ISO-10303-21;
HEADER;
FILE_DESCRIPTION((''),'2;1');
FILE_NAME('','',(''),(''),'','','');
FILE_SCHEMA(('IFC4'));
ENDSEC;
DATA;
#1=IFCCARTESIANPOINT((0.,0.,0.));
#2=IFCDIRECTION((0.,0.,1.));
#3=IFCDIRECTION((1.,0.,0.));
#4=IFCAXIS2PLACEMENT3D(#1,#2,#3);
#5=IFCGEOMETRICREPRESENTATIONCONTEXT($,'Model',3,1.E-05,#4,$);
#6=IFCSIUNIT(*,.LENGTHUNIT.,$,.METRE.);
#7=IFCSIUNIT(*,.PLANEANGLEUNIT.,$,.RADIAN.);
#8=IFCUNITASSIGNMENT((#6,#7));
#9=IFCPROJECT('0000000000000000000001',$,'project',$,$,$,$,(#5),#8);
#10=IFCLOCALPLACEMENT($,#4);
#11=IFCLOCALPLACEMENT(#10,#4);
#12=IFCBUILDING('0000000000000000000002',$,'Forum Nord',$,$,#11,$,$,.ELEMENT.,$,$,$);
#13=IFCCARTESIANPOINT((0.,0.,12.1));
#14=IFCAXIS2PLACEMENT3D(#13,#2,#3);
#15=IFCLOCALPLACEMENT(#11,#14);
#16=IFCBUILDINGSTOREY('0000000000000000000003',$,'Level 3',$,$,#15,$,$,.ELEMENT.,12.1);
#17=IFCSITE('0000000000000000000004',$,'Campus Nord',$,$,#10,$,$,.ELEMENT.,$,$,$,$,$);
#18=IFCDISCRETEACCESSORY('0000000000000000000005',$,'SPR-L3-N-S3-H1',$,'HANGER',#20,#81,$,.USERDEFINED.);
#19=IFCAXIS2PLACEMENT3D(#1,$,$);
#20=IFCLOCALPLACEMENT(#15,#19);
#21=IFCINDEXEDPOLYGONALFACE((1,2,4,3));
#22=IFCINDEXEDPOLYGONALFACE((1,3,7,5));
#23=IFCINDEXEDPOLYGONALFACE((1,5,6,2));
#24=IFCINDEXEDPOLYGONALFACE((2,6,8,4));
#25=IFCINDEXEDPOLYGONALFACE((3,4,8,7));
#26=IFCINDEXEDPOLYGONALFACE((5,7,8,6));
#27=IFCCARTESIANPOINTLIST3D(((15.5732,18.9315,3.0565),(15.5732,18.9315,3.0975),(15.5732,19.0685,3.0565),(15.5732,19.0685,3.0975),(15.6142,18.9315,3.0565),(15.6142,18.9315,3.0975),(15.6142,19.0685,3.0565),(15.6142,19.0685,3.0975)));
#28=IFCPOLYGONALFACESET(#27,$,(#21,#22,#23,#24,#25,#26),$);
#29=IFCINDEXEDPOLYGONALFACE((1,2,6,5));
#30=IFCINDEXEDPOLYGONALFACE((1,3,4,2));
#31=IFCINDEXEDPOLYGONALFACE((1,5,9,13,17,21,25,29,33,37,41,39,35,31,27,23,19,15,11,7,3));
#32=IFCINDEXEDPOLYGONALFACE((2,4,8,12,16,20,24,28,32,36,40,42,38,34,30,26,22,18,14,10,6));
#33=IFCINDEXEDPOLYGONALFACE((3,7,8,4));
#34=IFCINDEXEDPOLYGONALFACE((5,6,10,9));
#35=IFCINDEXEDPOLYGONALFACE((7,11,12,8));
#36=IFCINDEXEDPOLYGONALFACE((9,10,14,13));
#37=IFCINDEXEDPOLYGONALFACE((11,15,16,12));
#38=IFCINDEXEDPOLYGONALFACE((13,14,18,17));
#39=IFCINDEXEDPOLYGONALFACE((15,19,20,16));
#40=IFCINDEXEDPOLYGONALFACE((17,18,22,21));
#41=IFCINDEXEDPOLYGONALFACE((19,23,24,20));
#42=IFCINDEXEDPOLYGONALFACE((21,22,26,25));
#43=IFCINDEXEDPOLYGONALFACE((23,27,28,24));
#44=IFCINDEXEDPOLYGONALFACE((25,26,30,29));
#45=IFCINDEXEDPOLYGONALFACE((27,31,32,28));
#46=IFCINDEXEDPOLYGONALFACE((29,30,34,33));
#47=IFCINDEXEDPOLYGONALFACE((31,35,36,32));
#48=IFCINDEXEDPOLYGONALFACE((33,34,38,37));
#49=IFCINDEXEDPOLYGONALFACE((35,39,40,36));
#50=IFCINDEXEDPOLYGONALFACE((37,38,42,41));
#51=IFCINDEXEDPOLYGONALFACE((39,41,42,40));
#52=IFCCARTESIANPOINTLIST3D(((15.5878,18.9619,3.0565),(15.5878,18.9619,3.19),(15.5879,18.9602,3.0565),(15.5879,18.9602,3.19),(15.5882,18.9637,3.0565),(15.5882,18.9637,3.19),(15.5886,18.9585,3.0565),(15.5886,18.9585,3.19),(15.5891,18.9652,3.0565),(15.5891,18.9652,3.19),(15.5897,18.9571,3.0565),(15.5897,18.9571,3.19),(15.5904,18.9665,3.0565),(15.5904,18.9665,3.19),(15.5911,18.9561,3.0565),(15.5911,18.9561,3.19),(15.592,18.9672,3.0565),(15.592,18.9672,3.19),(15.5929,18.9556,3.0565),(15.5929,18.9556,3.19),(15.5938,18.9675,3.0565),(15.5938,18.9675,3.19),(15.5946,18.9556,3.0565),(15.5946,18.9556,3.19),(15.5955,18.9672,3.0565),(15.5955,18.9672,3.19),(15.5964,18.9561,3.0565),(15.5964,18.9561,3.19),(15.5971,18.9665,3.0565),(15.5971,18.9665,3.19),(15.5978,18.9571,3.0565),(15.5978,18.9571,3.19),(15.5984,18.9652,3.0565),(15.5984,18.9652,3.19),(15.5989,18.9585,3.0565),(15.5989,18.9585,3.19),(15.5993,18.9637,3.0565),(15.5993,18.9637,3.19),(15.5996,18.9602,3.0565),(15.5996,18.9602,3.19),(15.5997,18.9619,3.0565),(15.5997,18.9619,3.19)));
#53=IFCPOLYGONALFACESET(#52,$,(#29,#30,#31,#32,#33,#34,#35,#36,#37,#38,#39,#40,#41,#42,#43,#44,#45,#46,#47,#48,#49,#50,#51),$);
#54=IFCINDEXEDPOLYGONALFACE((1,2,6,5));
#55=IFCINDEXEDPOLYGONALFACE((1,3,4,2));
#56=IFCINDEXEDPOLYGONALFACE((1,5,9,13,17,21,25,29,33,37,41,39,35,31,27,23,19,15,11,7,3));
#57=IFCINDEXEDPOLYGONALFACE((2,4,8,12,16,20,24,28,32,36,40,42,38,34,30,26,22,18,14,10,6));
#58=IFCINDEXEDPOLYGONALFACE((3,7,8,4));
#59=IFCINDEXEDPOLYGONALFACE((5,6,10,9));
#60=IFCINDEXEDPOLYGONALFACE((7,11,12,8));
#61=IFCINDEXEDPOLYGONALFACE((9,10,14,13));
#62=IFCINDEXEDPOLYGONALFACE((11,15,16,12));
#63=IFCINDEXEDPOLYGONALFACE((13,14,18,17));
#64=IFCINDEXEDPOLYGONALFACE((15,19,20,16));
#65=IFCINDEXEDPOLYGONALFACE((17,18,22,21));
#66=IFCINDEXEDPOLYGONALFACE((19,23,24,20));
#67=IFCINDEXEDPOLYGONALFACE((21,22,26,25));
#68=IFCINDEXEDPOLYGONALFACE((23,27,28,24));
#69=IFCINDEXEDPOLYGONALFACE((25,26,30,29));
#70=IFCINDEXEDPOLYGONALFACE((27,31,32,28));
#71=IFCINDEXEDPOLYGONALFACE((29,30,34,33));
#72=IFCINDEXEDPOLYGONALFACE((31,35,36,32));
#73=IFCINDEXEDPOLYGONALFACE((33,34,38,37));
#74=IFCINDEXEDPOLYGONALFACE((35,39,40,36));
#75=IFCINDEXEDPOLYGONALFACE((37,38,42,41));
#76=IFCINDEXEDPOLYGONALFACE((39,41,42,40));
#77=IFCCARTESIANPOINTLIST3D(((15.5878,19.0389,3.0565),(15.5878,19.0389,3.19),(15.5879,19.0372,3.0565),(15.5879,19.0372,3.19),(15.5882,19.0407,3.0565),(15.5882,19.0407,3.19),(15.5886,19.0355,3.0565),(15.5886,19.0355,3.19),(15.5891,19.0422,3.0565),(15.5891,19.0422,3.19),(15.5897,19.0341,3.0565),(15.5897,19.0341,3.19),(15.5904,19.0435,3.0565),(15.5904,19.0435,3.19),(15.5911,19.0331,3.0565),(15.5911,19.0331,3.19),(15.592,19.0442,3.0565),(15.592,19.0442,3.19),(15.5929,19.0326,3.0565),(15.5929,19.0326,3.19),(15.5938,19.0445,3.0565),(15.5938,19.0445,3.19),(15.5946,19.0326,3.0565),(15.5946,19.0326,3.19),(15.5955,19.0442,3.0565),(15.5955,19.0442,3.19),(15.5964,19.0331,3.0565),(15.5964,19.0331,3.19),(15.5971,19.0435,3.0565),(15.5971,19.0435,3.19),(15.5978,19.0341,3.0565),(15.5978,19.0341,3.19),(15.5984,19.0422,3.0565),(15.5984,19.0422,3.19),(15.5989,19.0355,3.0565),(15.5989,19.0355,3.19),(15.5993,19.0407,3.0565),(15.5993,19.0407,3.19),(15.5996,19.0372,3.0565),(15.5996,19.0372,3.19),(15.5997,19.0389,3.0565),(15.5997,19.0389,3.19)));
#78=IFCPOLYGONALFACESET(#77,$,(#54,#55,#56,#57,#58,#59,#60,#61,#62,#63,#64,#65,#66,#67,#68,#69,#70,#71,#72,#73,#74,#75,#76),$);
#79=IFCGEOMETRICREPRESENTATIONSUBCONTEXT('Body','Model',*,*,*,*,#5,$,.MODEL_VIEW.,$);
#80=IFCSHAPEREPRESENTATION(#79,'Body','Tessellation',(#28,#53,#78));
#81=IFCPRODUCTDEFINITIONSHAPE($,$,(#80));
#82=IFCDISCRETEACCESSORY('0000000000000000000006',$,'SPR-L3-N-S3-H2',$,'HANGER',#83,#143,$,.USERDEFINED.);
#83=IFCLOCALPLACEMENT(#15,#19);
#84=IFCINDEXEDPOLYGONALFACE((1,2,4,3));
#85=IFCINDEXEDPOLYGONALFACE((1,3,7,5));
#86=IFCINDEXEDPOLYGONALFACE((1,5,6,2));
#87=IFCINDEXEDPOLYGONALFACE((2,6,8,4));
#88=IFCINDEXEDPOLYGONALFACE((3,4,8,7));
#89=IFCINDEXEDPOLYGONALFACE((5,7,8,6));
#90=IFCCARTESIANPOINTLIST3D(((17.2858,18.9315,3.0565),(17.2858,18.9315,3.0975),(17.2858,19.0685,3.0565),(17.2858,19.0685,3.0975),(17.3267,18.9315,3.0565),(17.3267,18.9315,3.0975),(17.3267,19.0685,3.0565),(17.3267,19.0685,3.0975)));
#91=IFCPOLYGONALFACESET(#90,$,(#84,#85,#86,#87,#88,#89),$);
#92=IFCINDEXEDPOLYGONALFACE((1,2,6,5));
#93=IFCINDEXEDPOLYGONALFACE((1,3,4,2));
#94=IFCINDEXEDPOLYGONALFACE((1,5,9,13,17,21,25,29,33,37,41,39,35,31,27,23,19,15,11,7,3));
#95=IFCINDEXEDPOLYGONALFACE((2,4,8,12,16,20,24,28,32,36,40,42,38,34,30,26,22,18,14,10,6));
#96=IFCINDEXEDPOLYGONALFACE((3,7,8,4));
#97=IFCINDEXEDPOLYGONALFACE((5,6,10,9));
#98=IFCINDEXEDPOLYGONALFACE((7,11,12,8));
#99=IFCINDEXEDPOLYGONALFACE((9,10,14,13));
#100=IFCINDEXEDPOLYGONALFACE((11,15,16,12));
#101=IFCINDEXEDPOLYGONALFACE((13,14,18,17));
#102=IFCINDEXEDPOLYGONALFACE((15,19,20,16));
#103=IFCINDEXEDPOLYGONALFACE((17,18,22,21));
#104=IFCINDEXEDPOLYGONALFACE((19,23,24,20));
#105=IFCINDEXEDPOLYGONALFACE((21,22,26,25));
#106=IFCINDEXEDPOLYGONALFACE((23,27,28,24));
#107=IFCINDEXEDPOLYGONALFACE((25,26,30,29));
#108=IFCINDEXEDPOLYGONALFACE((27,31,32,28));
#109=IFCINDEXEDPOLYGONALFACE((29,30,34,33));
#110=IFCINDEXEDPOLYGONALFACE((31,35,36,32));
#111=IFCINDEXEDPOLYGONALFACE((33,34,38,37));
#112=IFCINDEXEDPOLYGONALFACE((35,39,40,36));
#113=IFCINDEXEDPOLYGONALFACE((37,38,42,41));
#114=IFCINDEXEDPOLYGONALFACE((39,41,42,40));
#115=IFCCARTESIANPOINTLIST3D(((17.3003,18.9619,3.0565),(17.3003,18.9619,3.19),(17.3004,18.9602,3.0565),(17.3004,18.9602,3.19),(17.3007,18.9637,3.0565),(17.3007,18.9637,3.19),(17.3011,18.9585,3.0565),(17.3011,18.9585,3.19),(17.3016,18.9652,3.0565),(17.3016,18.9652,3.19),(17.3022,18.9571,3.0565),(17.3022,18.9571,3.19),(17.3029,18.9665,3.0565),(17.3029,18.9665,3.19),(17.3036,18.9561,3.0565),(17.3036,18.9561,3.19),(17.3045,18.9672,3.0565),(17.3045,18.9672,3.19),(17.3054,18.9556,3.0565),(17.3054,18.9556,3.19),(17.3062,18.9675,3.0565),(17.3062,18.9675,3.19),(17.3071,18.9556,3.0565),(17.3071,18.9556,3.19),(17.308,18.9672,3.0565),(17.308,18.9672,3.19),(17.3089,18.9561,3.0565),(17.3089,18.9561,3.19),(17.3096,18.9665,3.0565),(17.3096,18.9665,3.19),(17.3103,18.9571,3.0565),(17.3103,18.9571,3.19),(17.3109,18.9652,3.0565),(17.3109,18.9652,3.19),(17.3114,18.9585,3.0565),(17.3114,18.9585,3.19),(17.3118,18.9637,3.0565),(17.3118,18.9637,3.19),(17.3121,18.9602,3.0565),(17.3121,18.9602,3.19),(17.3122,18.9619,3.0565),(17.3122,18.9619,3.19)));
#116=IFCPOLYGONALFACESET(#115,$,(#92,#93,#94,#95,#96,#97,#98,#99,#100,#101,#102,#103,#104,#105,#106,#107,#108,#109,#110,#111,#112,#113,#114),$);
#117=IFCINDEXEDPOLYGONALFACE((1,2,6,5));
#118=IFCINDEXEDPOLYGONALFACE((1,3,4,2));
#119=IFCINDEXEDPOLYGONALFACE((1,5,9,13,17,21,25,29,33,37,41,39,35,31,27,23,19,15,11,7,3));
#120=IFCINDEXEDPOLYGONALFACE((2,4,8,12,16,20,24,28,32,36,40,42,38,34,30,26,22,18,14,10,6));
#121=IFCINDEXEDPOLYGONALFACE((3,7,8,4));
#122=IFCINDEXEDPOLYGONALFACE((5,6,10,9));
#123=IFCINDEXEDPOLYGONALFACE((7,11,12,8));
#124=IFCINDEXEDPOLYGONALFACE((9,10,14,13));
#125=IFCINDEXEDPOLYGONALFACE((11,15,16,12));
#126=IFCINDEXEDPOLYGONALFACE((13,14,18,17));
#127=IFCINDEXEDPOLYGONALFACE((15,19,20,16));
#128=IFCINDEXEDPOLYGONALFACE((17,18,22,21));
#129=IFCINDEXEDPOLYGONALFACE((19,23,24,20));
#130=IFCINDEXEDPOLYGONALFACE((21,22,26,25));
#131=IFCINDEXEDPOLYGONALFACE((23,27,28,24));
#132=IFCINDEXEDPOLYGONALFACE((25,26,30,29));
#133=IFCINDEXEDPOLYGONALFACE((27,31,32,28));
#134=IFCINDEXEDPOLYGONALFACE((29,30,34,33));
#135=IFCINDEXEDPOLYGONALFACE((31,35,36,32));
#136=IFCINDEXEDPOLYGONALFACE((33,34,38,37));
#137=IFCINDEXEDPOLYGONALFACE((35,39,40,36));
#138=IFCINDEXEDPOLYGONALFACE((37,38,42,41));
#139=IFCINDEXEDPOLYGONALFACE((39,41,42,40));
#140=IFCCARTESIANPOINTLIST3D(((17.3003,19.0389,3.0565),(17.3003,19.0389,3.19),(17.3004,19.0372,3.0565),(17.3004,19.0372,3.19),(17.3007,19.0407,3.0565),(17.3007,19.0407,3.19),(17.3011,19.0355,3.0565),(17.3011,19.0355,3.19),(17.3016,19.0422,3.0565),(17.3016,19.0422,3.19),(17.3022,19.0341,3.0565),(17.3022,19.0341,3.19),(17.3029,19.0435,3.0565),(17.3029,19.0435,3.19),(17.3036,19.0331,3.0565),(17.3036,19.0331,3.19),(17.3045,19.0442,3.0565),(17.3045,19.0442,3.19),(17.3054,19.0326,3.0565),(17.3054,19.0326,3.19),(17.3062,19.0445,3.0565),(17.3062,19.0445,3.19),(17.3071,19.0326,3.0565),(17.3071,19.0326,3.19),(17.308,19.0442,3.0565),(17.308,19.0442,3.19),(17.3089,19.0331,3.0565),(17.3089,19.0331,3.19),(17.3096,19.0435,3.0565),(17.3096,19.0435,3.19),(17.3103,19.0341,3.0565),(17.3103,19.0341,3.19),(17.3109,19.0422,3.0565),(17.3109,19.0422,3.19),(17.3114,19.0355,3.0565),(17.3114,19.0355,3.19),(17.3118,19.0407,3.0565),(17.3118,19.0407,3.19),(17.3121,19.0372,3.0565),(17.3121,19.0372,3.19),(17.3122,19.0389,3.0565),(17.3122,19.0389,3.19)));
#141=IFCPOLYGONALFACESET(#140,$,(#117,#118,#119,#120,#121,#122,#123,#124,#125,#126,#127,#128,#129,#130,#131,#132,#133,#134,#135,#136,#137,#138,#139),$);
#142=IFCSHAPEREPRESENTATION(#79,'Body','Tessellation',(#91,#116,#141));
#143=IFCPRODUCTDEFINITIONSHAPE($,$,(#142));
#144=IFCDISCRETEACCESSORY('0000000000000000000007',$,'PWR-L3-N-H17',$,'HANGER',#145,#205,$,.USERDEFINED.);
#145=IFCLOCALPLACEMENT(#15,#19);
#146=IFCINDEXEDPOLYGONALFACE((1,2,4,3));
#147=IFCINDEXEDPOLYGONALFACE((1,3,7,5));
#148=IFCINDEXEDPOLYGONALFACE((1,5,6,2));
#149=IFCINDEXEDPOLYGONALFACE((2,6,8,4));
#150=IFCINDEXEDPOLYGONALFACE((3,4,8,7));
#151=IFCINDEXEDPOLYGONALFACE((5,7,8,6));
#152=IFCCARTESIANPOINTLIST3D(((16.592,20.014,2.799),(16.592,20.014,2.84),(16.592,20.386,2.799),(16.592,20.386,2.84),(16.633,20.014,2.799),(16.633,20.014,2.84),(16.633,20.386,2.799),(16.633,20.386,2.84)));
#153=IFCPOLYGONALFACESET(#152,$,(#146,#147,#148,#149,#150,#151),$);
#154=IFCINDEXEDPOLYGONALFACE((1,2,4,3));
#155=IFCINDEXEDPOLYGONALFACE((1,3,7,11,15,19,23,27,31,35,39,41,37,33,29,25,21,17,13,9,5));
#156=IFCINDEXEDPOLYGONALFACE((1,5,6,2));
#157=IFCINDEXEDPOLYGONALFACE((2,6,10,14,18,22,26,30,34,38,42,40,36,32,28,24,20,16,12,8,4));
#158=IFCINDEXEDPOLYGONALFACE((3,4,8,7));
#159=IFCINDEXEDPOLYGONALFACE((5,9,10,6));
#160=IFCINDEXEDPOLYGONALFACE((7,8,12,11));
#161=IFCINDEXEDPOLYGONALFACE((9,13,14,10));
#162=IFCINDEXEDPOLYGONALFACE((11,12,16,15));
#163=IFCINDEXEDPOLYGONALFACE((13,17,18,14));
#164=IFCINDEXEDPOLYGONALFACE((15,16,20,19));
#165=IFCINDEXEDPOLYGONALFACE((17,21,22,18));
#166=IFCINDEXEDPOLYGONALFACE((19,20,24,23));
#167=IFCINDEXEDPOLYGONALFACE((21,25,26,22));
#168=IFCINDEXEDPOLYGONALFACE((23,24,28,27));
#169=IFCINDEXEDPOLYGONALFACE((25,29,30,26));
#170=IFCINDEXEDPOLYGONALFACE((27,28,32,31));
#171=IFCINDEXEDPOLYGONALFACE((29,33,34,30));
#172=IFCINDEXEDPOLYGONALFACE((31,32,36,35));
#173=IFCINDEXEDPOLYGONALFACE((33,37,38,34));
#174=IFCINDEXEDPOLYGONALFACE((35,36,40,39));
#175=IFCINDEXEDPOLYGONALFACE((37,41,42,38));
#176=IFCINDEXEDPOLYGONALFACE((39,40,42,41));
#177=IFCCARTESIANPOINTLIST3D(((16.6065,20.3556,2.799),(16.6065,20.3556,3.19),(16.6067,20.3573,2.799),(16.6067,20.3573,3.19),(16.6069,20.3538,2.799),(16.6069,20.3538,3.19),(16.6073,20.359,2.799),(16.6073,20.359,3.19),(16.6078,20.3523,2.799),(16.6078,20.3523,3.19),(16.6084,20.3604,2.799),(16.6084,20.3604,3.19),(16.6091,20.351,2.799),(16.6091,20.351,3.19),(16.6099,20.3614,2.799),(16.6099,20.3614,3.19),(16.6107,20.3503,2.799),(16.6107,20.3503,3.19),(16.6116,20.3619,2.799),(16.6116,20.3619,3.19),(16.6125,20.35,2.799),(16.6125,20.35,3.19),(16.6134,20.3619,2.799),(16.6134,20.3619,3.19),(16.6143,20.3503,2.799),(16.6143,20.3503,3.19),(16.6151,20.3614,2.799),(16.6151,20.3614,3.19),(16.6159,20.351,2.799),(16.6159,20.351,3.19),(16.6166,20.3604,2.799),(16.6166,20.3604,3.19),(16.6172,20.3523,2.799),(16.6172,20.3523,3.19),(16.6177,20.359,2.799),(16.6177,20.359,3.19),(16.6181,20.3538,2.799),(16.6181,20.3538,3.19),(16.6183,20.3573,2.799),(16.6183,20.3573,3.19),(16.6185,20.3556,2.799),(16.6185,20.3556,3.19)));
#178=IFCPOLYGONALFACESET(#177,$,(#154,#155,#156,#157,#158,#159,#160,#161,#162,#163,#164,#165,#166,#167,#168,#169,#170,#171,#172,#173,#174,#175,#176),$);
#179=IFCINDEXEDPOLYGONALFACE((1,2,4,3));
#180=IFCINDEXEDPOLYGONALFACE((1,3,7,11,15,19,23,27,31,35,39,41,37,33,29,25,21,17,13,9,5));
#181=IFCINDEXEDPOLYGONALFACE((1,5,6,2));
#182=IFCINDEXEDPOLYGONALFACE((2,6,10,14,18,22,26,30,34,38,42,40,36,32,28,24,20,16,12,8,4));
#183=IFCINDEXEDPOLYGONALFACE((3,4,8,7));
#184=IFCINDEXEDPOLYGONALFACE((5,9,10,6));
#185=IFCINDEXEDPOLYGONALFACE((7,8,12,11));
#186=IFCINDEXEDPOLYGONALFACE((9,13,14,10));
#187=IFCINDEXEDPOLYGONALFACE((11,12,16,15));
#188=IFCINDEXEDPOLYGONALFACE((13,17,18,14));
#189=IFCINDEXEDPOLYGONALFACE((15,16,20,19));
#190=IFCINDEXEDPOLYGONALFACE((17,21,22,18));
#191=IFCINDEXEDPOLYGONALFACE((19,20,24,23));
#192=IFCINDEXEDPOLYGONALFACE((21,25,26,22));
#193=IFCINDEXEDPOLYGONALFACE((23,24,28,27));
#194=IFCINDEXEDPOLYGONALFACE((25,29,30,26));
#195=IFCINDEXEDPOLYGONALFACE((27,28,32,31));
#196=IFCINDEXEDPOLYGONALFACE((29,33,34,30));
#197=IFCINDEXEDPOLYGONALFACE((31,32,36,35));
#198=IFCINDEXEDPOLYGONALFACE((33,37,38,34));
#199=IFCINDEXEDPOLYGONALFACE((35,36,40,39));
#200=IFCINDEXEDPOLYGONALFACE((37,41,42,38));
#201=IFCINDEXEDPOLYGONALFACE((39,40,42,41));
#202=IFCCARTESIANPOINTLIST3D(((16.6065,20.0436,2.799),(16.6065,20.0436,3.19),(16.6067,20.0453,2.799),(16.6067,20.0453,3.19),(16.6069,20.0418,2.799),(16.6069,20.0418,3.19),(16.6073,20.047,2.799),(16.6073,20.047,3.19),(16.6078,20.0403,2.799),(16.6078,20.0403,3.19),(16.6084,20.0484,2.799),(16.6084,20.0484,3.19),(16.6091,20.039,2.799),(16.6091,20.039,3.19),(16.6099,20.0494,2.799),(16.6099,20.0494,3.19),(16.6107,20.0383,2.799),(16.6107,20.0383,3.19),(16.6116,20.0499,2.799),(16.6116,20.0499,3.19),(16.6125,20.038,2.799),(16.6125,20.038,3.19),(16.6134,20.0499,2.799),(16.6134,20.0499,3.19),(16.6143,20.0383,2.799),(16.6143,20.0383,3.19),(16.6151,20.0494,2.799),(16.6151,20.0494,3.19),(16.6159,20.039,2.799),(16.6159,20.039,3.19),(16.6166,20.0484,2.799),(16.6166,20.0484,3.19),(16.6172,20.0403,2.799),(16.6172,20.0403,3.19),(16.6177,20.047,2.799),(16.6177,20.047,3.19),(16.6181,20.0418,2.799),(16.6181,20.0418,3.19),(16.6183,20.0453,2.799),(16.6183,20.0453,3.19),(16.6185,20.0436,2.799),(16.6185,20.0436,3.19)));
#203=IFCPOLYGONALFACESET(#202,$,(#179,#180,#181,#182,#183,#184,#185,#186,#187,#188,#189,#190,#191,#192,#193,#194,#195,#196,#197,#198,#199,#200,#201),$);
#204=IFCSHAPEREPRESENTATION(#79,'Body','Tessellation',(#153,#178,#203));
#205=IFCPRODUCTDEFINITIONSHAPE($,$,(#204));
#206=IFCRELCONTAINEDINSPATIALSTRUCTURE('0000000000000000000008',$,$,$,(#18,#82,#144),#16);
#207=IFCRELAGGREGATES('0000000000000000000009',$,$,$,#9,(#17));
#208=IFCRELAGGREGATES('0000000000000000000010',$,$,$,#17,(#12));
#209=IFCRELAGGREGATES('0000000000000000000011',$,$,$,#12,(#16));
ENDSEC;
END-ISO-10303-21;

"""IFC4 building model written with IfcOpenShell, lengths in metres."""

from ifc_helpers import new_model, si_unit, frame, frame_2d, origin_with_axes, origin_2d_with_axis, place, context, subcontext, project, spatial, rectangle, circle, extrude, element, save


model = new_model("IFC4")

# Units and contexts
model_context = context("Model", 3, precision=1e-05, world=origin_with_axes())
body_context = subcontext(model_context, "Body", "Model", "MODEL_VIEW")
ifc_project = project(units=[si_unit("LENGTHUNIT", "METRE"), si_unit("PLANEANGLEUNIT", "RADIAN")], contexts=[model_context])

# Site, building, storey
site_placement = place(None, origin_with_axes())
site = spatial("IfcSite", under=ifc_project, at=site_placement, Name="Campus Nord", CompositionType="ELEMENT")
building_placement = place(site_placement, origin_with_axes())
building = spatial("IfcBuilding", under=site, at=building_placement, Name="Forum Nord", CompositionType="ELEMENT")
storey_placement = place(building_placement, frame((0.0, 0.0, 12.1), z_axis=(0.0, 0.0, 1.0), x_axis=(1.0, 0.0, 0.0)))
storey = spatial("IfcBuildingStorey", under=building, at=storey_placement, Name="Level 3", CompositionType="ELEMENT", Elevation=12.1)

# Discrete accessories
for number, where, z_axis, x_axis, name in (
    (1, (15.5938, 19.0, 3.0975), (0.0, 0.0, 1.0), (0.0, 1.0, 0.0), "SPR-L3-N-S3-H1"),
    (2, (17.3062, 19.0, 3.0975), (0.0, 0.0, 1.0), (0.0, 1.0, 0.0), "SPR-L3-N-S3-H2"),
):
    element("IfcDiscreteAccessory", number, at=place(storey_placement, frame(where, z_axis=z_axis, x_axis=x_axis)), inside=storey, Name=name, ObjectType="HANGER", PredefinedType="USERDEFINED", context=body_context, shape_type="SweptSolid", body=[
        extrude(rectangle(XDim=0.137, YDim=0.041, at=origin_2d_with_axis()), frame((0.0, 0.0, -0.041), z_axis=(0.0, 0.0, 1.0), x_axis=(1.0, 0.0, 0.0)), (0.0, 0.0, 1.0), 0.041),
        extrude(circle(Radius=0.006, at=frame_2d((-0.0385, 0.0), x_axis=(1.0, 0.0))), frame((0.0, 0.0, -0.041), z_axis=(0.0, 0.0, 1.0), x_axis=(1.0, 0.0, 0.0)), (0.0, 0.0, 1.0), 0.1335),
        extrude(circle(Radius=0.006, at=frame_2d((0.0385, 0.0), x_axis=(1.0, 0.0))), frame((0.0, 0.0, -0.041), z_axis=(0.0, 0.0, 1.0), x_axis=(1.0, 0.0, 0.0)), (0.0, 0.0, 1.0), 0.1335),
    ])
for number, where, z_axis, x_axis, name in (
    (3, (16.6125, 20.2, 2.84), (0.0, 0.0, 1.0), (0.0, -1.0, 0.0), "PWR-L3-N-H17"),
):
    element("IfcDiscreteAccessory", number, at=place(storey_placement, frame(where, z_axis=z_axis, x_axis=x_axis)), inside=storey, Name=name, ObjectType="HANGER", PredefinedType="USERDEFINED", context=body_context, shape_type="SweptSolid", body=[
        extrude(rectangle(XDim=0.372, YDim=0.041, at=origin_2d_with_axis()), frame((0.0, 0.0, -0.041), z_axis=(0.0, 0.0, 1.0), x_axis=(1.0, 0.0, 0.0)), (0.0, 0.0, 1.0), 0.041),
        extrude(circle(Radius=0.006, at=frame_2d((-0.156, 0.0), x_axis=(1.0, 0.0))), frame((0.0, 0.0, -0.041), z_axis=(0.0, 0.0, 1.0), x_axis=(1.0, 0.0, 0.0)), (0.0, 0.0, 1.0), 0.391),
        extrude(circle(Radius=0.006, at=frame_2d((0.156, 0.0), x_axis=(1.0, 0.0))), frame((0.0, 0.0, -0.041), z_axis=(0.0, 0.0, 1.0), x_axis=(1.0, 0.0, 0.0)), (0.0, 0.0, 1.0), 0.391),
    ])

save(model, "model.ifc")
